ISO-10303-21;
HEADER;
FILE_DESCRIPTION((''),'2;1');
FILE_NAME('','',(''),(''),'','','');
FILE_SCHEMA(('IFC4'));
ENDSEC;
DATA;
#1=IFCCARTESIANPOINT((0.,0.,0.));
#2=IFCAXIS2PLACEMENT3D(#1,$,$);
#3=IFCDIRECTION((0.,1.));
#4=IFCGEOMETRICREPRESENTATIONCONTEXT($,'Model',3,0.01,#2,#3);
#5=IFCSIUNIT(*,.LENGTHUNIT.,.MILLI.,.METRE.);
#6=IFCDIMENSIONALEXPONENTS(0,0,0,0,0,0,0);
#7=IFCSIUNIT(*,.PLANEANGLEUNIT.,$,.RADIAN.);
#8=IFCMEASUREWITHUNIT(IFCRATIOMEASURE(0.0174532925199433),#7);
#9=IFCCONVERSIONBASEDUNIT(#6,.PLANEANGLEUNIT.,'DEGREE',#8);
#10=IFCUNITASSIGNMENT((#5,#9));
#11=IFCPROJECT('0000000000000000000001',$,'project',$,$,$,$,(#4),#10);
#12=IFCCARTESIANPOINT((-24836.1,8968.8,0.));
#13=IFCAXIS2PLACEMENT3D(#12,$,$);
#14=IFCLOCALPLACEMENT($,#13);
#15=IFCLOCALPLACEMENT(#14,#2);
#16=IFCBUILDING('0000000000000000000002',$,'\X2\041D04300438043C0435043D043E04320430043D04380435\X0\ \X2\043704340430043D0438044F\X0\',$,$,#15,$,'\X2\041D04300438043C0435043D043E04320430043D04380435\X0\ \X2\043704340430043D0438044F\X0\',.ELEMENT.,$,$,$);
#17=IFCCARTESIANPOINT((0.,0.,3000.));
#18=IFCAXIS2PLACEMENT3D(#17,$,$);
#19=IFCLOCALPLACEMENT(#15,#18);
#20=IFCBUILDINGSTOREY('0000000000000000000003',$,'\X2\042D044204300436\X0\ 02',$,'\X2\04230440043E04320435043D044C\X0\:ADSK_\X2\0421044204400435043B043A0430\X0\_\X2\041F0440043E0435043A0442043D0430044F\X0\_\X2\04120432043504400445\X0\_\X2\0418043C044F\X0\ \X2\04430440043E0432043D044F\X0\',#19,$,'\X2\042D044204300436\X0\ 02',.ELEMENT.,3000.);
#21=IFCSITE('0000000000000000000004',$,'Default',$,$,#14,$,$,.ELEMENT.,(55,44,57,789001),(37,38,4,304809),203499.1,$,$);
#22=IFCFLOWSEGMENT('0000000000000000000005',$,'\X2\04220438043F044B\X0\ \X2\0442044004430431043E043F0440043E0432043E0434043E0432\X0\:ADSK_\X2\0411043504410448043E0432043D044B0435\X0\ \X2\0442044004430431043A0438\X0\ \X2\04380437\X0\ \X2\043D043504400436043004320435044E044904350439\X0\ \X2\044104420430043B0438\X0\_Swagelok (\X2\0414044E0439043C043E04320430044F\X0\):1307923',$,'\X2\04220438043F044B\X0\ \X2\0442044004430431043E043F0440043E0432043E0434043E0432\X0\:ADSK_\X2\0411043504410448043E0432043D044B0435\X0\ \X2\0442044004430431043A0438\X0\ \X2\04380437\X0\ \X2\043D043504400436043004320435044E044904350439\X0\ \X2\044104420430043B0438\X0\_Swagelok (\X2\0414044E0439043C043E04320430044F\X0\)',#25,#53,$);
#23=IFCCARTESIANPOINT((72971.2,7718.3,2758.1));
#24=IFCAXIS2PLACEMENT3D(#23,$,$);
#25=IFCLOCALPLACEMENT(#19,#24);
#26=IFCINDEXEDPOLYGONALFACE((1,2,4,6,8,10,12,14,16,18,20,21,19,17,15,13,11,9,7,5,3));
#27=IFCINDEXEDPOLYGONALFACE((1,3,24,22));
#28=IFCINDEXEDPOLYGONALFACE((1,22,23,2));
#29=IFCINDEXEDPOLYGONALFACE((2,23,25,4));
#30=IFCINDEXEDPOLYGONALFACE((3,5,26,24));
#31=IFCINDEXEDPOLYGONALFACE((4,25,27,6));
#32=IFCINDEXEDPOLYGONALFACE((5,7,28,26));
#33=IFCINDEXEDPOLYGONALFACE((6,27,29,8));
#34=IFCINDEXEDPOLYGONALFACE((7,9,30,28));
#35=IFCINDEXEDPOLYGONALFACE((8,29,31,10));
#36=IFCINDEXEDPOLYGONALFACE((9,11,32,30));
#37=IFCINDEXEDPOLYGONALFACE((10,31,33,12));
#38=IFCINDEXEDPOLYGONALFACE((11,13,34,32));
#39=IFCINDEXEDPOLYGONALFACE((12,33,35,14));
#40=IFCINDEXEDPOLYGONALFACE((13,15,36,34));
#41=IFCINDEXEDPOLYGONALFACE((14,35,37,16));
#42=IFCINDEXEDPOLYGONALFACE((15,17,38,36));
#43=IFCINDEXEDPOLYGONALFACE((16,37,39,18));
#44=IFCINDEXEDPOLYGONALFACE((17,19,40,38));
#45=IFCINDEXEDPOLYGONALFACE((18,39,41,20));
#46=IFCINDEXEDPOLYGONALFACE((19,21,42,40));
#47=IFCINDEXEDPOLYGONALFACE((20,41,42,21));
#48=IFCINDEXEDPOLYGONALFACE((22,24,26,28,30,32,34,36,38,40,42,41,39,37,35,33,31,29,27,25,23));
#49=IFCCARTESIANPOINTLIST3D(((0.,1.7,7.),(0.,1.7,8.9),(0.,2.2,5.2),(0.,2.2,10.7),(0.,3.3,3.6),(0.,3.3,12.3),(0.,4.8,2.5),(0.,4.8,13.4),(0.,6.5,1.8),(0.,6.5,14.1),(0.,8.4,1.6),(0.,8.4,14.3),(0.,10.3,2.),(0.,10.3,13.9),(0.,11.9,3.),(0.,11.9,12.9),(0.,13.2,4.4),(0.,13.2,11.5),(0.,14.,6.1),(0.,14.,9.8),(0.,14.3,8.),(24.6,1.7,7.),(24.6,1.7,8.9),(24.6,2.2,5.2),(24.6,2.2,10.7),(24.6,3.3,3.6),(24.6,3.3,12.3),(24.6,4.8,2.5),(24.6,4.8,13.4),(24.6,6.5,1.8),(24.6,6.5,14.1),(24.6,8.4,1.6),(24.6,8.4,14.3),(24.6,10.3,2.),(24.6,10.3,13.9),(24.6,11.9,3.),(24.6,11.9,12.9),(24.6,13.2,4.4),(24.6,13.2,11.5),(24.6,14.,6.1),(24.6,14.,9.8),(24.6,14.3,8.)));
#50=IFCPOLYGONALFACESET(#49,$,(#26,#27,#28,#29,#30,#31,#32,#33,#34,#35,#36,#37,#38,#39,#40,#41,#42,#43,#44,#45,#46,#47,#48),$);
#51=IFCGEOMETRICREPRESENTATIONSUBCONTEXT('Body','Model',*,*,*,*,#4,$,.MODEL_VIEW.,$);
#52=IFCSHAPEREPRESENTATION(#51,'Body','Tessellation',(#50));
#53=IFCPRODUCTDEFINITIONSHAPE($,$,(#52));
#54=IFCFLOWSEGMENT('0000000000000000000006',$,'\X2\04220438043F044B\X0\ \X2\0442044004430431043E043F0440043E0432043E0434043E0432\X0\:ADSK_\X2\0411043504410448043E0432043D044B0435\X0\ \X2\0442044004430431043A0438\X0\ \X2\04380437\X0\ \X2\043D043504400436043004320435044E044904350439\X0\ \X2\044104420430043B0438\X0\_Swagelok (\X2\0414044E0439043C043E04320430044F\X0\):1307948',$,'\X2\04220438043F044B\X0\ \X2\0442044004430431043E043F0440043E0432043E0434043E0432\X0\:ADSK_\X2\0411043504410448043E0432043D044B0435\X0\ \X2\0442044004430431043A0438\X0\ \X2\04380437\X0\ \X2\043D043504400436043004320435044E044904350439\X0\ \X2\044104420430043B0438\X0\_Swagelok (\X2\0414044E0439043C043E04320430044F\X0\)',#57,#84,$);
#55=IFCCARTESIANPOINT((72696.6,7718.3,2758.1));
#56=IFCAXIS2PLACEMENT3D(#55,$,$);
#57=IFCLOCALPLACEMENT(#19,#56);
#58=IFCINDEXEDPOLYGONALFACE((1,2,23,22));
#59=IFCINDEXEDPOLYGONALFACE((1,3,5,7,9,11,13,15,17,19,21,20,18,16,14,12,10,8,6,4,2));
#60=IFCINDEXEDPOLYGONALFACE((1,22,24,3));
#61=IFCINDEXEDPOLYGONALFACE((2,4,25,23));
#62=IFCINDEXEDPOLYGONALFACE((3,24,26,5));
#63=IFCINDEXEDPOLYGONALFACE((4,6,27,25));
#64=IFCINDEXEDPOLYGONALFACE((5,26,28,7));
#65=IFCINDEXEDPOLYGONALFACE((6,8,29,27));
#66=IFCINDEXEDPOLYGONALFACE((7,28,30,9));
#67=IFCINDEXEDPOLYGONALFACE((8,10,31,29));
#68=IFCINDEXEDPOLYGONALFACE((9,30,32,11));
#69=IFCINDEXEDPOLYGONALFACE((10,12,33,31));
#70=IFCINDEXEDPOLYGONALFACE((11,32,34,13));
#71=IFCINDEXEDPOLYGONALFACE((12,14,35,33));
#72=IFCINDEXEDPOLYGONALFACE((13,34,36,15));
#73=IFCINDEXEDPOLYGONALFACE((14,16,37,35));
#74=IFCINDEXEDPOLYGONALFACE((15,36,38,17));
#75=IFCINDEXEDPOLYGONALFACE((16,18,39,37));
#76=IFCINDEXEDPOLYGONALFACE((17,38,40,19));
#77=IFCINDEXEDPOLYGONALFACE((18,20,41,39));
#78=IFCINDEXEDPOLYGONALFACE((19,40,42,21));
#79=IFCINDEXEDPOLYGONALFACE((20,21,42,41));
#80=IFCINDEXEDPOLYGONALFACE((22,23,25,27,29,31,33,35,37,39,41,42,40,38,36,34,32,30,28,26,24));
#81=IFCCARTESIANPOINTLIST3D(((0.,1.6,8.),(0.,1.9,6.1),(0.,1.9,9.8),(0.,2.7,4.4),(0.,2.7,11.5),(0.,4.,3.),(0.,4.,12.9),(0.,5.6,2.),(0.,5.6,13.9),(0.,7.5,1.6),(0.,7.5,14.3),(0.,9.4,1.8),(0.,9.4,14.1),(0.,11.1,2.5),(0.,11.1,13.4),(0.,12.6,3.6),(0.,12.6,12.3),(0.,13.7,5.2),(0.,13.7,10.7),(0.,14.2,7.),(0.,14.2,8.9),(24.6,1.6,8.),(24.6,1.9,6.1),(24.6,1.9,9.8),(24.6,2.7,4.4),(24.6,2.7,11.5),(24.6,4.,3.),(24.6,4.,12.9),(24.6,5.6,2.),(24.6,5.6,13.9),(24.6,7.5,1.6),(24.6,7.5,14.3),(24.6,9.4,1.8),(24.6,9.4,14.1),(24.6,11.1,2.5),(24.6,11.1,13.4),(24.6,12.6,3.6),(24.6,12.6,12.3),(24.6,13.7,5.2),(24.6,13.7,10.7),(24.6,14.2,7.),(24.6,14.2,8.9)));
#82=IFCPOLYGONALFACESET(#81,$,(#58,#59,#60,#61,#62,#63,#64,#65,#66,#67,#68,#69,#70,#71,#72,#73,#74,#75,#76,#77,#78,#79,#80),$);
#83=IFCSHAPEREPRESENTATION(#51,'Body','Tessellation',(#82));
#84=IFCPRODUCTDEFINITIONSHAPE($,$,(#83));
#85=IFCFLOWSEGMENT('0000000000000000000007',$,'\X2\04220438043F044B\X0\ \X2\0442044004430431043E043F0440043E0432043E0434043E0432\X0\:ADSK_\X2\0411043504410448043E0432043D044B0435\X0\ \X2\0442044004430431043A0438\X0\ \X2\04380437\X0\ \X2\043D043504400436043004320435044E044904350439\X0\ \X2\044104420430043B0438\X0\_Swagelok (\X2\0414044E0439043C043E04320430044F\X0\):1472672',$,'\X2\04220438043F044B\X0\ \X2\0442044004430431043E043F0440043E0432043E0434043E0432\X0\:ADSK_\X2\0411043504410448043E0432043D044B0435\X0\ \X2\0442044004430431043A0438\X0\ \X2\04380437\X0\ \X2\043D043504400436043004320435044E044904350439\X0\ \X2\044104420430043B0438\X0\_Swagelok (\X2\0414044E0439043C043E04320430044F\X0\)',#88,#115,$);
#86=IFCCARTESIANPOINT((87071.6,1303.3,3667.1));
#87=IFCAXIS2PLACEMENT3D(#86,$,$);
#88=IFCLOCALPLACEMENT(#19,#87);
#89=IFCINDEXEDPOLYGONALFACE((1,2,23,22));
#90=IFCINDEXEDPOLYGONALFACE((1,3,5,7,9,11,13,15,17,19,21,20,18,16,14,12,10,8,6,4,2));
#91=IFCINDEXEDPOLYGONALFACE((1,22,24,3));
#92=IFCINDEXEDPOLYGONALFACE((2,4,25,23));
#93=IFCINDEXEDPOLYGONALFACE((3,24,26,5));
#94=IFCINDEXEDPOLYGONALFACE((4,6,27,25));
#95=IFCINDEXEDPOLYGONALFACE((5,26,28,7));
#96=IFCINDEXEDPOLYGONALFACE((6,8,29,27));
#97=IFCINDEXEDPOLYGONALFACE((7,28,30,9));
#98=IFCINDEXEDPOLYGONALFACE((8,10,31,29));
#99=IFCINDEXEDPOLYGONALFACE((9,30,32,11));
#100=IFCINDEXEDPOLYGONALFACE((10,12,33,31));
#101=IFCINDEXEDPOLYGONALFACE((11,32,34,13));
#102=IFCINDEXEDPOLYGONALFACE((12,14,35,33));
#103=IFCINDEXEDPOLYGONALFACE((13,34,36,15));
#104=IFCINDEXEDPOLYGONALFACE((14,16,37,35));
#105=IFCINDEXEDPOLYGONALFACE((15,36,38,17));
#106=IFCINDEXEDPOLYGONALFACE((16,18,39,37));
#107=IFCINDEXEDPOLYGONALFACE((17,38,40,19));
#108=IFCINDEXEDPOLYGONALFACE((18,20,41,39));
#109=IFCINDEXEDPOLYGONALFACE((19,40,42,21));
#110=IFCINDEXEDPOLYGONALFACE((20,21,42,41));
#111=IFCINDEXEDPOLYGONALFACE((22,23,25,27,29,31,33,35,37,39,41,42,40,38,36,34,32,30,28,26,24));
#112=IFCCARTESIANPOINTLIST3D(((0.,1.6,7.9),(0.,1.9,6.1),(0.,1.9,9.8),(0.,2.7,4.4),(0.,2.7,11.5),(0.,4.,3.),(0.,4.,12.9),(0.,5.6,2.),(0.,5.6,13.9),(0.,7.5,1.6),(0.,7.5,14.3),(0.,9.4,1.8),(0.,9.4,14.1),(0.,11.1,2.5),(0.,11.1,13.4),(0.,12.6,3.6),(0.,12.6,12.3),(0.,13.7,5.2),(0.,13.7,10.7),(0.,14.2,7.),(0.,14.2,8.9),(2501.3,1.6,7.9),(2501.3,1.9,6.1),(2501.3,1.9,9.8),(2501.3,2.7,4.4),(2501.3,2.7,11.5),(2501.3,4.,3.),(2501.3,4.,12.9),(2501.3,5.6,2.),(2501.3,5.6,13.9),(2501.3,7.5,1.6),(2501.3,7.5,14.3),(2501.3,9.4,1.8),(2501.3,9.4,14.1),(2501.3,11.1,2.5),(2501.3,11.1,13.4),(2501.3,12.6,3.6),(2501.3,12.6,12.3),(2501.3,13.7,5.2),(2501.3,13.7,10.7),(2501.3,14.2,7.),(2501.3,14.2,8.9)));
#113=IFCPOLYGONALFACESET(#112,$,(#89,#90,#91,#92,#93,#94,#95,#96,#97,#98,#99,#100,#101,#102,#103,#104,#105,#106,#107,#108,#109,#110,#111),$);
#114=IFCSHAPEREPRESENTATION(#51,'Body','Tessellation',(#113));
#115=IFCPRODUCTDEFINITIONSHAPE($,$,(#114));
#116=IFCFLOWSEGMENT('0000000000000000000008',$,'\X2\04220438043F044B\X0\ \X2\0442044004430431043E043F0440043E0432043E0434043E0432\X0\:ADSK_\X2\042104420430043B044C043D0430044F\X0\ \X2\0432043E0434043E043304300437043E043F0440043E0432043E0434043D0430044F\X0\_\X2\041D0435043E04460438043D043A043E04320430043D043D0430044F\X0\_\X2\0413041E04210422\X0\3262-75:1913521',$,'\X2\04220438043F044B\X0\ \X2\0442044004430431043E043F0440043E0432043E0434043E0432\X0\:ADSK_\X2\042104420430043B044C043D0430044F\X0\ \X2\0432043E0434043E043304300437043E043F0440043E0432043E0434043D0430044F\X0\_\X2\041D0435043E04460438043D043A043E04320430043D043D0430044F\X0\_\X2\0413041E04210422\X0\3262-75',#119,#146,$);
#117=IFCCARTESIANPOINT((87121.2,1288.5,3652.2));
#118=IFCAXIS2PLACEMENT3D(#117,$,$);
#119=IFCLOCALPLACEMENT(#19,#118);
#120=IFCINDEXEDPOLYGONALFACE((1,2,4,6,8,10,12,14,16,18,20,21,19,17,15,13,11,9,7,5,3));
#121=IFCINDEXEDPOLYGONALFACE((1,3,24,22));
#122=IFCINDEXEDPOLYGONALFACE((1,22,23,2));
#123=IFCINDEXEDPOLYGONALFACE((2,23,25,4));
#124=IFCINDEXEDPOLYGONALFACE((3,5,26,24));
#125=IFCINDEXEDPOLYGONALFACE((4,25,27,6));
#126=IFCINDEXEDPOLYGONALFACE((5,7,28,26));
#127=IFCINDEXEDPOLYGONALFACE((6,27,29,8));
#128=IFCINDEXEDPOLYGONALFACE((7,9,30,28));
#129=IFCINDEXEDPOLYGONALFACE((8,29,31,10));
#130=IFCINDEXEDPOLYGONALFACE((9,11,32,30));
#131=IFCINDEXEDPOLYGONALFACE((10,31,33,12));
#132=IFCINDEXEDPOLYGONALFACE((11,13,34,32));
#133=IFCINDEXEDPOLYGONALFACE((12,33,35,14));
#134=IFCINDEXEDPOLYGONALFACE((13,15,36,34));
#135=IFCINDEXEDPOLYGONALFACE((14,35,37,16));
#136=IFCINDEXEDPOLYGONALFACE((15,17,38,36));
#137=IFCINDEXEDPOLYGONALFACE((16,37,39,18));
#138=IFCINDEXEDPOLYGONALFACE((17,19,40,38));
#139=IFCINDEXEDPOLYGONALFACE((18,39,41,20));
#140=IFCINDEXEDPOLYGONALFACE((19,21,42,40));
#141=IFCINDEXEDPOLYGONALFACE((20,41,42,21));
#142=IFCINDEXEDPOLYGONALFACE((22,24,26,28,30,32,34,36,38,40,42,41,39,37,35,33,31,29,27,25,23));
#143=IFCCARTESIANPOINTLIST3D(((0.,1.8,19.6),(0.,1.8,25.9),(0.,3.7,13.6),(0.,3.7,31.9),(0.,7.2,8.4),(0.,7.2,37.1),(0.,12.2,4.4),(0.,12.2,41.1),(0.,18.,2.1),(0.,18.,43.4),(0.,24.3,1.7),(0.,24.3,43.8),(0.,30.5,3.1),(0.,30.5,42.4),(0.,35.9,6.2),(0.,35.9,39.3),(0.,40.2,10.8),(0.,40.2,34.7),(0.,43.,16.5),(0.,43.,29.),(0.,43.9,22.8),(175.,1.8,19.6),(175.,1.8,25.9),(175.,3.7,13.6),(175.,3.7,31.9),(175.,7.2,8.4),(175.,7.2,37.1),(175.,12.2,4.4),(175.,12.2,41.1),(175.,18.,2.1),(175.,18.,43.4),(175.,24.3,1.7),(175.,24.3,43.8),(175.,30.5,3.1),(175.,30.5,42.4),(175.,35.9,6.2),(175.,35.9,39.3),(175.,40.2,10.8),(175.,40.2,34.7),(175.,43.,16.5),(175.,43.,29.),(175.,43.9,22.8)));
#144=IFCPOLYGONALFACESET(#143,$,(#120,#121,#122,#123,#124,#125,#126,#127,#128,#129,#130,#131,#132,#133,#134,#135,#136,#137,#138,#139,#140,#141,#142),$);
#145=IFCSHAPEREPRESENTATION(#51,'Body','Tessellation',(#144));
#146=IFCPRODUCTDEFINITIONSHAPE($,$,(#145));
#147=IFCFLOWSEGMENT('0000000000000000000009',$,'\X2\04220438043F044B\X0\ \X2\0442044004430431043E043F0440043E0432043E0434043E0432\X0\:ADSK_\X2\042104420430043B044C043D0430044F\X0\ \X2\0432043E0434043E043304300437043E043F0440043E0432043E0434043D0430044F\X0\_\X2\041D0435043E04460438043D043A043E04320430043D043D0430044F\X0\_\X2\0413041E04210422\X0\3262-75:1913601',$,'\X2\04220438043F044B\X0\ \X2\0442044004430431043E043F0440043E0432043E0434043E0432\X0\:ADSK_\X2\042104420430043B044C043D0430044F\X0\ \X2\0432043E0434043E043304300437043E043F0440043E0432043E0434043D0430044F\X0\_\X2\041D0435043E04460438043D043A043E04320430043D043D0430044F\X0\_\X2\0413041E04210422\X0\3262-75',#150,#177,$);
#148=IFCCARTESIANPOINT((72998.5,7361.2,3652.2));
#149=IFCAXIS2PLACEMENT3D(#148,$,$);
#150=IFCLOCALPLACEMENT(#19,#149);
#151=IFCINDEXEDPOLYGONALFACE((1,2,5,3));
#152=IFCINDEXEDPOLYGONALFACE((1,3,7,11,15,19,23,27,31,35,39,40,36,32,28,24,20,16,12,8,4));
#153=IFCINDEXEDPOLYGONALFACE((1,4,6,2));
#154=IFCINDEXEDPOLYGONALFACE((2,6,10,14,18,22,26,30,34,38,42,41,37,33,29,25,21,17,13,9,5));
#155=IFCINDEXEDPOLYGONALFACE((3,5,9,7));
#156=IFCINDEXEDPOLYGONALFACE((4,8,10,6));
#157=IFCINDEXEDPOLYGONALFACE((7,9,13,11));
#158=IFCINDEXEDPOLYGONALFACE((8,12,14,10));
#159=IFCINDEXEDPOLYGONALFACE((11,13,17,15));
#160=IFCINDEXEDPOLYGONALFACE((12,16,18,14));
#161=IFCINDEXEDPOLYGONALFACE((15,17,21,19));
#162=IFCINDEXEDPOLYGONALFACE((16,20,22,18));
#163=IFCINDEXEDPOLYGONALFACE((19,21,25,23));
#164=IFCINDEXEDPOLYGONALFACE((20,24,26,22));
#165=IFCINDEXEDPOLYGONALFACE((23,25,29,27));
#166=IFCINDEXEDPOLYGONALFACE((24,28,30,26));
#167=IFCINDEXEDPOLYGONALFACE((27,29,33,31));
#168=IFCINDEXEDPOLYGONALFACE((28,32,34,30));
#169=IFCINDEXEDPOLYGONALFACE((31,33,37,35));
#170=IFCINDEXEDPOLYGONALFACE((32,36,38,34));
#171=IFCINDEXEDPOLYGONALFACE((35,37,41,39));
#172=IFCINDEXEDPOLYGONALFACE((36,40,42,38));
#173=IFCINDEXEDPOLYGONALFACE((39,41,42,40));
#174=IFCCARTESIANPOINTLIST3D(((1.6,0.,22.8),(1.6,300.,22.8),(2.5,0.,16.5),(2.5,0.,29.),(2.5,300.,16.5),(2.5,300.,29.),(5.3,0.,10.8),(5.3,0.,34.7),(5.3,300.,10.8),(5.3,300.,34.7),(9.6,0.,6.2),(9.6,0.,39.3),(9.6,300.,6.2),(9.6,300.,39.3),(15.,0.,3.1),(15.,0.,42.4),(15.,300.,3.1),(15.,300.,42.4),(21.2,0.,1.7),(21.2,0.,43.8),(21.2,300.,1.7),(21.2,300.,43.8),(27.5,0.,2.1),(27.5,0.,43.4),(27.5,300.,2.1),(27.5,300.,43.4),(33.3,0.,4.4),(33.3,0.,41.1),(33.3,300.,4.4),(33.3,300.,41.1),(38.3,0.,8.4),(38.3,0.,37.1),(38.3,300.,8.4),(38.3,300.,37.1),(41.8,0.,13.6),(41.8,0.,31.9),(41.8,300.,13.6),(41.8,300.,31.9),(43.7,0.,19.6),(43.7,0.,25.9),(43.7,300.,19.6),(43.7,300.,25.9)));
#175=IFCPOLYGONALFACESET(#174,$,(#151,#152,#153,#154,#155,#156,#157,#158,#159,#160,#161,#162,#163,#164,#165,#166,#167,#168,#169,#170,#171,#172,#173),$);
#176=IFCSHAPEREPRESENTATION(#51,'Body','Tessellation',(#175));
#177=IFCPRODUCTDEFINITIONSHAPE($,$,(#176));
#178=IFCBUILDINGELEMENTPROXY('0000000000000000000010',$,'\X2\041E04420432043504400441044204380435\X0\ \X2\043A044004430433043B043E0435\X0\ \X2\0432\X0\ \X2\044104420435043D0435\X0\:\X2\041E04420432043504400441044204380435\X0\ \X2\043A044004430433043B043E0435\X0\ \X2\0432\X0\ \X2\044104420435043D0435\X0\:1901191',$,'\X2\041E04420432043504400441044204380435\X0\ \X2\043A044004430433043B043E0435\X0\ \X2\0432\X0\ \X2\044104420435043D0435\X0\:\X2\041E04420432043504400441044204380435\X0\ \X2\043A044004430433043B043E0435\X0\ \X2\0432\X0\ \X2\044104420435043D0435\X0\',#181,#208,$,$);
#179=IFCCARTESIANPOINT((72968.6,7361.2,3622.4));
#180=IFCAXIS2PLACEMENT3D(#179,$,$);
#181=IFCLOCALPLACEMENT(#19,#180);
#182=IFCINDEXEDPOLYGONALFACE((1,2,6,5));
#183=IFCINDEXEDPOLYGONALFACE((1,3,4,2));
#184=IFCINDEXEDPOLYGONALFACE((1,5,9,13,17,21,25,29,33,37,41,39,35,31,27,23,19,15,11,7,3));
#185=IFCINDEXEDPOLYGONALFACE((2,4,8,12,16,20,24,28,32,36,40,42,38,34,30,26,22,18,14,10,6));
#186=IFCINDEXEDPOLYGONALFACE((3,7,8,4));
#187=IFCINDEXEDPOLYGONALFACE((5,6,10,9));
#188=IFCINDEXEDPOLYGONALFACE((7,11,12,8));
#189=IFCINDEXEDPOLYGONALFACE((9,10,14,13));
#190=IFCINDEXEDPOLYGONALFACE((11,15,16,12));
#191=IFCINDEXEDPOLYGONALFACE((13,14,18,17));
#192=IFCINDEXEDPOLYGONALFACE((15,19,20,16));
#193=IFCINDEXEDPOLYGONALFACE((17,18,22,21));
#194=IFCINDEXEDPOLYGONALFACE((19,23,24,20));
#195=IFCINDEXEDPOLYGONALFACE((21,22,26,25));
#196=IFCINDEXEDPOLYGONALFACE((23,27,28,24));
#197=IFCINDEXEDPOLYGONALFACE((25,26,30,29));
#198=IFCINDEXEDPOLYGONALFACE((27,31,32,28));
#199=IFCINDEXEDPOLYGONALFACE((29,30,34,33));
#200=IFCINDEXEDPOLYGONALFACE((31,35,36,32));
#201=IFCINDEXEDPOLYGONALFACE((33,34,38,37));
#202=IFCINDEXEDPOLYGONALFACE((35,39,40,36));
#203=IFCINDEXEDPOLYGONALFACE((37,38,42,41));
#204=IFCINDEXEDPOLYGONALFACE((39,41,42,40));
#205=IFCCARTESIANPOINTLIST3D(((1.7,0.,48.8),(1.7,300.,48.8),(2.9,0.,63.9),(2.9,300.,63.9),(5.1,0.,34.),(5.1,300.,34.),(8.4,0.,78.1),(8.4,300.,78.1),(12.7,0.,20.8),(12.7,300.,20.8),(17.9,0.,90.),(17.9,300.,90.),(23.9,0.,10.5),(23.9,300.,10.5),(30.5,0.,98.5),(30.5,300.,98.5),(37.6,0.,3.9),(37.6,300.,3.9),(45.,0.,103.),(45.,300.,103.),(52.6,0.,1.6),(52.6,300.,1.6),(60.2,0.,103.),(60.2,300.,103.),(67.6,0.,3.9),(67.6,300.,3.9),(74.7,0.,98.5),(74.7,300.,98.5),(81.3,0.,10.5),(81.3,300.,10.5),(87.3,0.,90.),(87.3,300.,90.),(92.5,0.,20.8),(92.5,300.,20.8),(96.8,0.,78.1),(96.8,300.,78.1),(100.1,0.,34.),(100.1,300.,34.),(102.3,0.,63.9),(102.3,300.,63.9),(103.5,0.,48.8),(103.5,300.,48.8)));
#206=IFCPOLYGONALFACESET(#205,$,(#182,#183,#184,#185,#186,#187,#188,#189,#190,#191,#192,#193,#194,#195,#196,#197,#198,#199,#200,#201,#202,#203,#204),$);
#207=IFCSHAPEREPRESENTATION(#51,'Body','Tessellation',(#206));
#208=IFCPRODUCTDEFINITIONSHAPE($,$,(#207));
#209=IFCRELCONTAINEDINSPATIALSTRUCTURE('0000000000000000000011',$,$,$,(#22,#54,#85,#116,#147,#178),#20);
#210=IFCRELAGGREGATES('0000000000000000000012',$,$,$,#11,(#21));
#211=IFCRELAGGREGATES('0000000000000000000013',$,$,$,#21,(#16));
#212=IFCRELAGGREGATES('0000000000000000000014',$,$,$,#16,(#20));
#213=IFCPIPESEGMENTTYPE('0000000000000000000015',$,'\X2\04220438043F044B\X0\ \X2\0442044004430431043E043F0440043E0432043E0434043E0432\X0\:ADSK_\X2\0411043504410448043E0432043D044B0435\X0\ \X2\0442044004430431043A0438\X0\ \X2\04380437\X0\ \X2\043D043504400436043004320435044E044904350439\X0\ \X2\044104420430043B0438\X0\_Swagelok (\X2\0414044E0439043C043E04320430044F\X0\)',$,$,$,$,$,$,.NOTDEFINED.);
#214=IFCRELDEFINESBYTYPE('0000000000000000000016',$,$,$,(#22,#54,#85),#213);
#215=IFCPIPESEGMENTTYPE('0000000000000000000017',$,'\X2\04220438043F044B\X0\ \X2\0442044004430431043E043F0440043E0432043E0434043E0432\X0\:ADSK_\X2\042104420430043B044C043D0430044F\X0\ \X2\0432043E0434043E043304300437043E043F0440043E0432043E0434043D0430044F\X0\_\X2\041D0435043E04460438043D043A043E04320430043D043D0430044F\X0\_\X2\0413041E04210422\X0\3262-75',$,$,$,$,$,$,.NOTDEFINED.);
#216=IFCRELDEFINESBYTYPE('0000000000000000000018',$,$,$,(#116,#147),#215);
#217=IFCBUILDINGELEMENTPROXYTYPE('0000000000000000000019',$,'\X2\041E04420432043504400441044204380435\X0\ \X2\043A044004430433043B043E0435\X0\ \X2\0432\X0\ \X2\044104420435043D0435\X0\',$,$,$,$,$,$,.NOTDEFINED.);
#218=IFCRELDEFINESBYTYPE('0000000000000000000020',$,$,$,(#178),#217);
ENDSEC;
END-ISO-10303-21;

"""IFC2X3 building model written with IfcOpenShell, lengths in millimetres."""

from ifc_helpers import new_model, entity, si_unit, converted_unit, direction, frame, origin, origin_2d_with_axis, place, context, subcontext, project, spatial, circle, extrude, type_object, element, save


model = new_model("IFC2X3")

# Units and contexts
model_context = context("Model", 3, precision=0.01, world=origin(), true_north=direction((0.0, 1.0)))
body_context = subcontext(model_context, "Body", "Model", "MODEL_VIEW")
ifc_project = project(units=[si_unit("LENGTHUNIT", "METRE", prefix="MILLI"), converted_unit("PLANEANGLEUNIT", "DEGREE", entity("IfcRatioMeasure", 0.0174532925199433), si_unit("PLANEANGLEUNIT", "RADIAN"), dimensions=[0, 0, 0, 0, 0, 0, 0])], contexts=[model_context])

# Site, building, storey
site_placement = place(None, frame((-24836.1, 8968.8, 0.0)))
site = spatial("IfcSite", under=ifc_project, at=site_placement, Name="Default", CompositionType="ELEMENT", RefLatitude=(55, 44, 57, 789001), RefLongitude=(37, 38, 4, 304809), RefElevation=203499.1)
building_placement = place(site_placement, origin())
building = spatial("IfcBuilding", under=site, at=building_placement, Name="Наименование здания", LongName="Наименование здания", CompositionType="ELEMENT")
storey_placement = place(building_placement, frame((0.0, 0.0, 3000.0)))
storey = spatial("IfcBuildingStorey", under=building, at=storey_placement, Name="Этаж 02", ObjectType="Уровень:ADSK_Стрелка_Проектная_Вверх_Имя уровня", LongName="Этаж 02", CompositionType="ELEMENT", Elevation=3000.0)

# Flow segments
pipe_segment_type_1 = type_object("IfcPipeSegmentType", Name="Типы трубопроводов:ADSK_Бесшовные трубки из нержавеющей стали_Swagelok (Дюймовая)", PredefinedType="NOTDEFINED")
flow_segment_1_placement = place(storey_placement, frame((72971.2, 7718.3, 2758.1)))
element("IfcFlowSegment", 1, at=flow_segment_1_placement, inside=storey, type_object=pipe_segment_type_1, Name="Типы трубопроводов:ADSK_Бесшовные трубки из нержавеющей стали_Swagelok (Дюймовая):1307923", ObjectType="Типы трубопроводов:ADSK_Бесшовные трубки из нержавеющей стали_Swagelok (Дюймовая)", context=body_context, shape_type="SweptSolid", body=[
    extrude(circle(Radius=6.3, at=origin_2d_with_axis()), frame((0.0, 8.0, 8.0), z_axis=(1.0, 0.0, 0.0), x_axis=(0.0, 1.0, 0.0)), (0.0, 0.0, 1.0), 24.6),
])
flow_segment_2_placement = place(storey_placement, frame((72696.6, 7718.3, 2758.1)))
element("IfcFlowSegment", 2, at=flow_segment_2_placement, inside=storey, type_object=pipe_segment_type_1, Name="Типы трубопроводов:ADSK_Бесшовные трубки из нержавеющей стали_Swagelok (Дюймовая):1307948", ObjectType="Типы трубопроводов:ADSK_Бесшовные трубки из нержавеющей стали_Swagelok (Дюймовая)", context=body_context, shape_type="SweptSolid", body=[
    extrude(circle(Radius=6.3, at=origin_2d_with_axis()), frame((0.0, 8.0, 8.0), z_axis=(1.0, 0.0, 0.0), x_axis=(0.0, -1.0, 0.0)), (0.0, 0.0, 1.0), 24.6),
])
flow_segment_3_placement = place(storey_placement, frame((87071.6, 1303.3, 3667.1)))
element("IfcFlowSegment", 3, at=flow_segment_3_placement, inside=storey, type_object=pipe_segment_type_1, Name="Типы трубопроводов:ADSK_Бесшовные трубки из нержавеющей стали_Swagelok (Дюймовая):1472672", ObjectType="Типы трубопроводов:ADSK_Бесшовные трубки из нержавеющей стали_Swagelok (Дюймовая)", context=body_context, shape_type="SweptSolid", body=[
    extrude(circle(Radius=6.3, at=origin_2d_with_axis()), frame((0.0, 8.0, 8.0), z_axis=(1.0, 0.0, 0.0), x_axis=(0.0, -1.0, 0.0)), (0.0, 0.0, 1.0), 2501.3),
])
pipe_segment_type_2 = type_object("IfcPipeSegmentType", Name="Типы трубопроводов:ADSK_Стальная водогазопроводная_Неоцинкованная_ГОСТ3262-75", PredefinedType="NOTDEFINED")
flow_segment_4_placement = place(storey_placement, frame((87121.2, 1288.5, 3652.2)))
element("IfcFlowSegment", 4, at=flow_segment_4_placement, inside=storey, type_object=pipe_segment_type_2, Name="Типы трубопроводов:ADSK_Стальная водогазопроводная_Неоцинкованная_ГОСТ3262-75:1913521", ObjectType="Типы трубопроводов:ADSK_Стальная водогазопроводная_Неоцинкованная_ГОСТ3262-75", context=body_context, shape_type="SweptSolid", body=[
    extrude(circle(Radius=21.1, at=origin_2d_with_axis()), frame((0.0, 22.8, 22.8), z_axis=(1.0, 0.0, 0.0), x_axis=(0.0, 1.0, 0.0)), (0.0, 0.0, 1.0), 175.0),
])
flow_segment_5_placement = place(storey_placement, frame((72998.5, 7361.2, 3652.2)))
element("IfcFlowSegment", 5, at=flow_segment_5_placement, inside=storey, type_object=pipe_segment_type_2, Name="Типы трубопроводов:ADSK_Стальная водогазопроводная_Неоцинкованная_ГОСТ3262-75:1913601", ObjectType="Типы трубопроводов:ADSK_Стальная водогазопроводная_Неоцинкованная_ГОСТ3262-75", context=body_context, shape_type="SweptSolid", body=[
    extrude(circle(Radius=21.1, at=origin_2d_with_axis()), frame((22.8, 0.0, 22.8), z_axis=(0.0, 1.0, 0.0), x_axis=(-1.0, 0.0, 0.0)), (0.0, 0.0, 1.0), 300.0),
])

# Building element proxy
building_element_proxy_type_1 = type_object("IfcBuildingElementProxyType", Name="Отверстие круглое в стене", PredefinedType="NOTDEFINED")
proxy_1_placement = place(storey_placement, frame((72968.6, 7361.2, 3622.4)))
element("IfcBuildingElementProxy", 6, at=proxy_1_placement, inside=storey, type_object=building_element_proxy_type_1, Name="Отверстие круглое в стене:Отверстие круглое в стене:1901191", ObjectType="Отверстие круглое в стене:Отверстие круглое в стене", context=body_context, shape_type="SweptSolid", body=[
    extrude(circle(Radius=51.0, at=origin_2d_with_axis()), frame((52.6, 0.0, 52.6), z_axis=(0.0, 1.0, 0.0), x_axis=(0.0, 0.0, -1.0)), (0.0, 0.0, 1.0), 300.0),
])

save(model, "model.ifc")
